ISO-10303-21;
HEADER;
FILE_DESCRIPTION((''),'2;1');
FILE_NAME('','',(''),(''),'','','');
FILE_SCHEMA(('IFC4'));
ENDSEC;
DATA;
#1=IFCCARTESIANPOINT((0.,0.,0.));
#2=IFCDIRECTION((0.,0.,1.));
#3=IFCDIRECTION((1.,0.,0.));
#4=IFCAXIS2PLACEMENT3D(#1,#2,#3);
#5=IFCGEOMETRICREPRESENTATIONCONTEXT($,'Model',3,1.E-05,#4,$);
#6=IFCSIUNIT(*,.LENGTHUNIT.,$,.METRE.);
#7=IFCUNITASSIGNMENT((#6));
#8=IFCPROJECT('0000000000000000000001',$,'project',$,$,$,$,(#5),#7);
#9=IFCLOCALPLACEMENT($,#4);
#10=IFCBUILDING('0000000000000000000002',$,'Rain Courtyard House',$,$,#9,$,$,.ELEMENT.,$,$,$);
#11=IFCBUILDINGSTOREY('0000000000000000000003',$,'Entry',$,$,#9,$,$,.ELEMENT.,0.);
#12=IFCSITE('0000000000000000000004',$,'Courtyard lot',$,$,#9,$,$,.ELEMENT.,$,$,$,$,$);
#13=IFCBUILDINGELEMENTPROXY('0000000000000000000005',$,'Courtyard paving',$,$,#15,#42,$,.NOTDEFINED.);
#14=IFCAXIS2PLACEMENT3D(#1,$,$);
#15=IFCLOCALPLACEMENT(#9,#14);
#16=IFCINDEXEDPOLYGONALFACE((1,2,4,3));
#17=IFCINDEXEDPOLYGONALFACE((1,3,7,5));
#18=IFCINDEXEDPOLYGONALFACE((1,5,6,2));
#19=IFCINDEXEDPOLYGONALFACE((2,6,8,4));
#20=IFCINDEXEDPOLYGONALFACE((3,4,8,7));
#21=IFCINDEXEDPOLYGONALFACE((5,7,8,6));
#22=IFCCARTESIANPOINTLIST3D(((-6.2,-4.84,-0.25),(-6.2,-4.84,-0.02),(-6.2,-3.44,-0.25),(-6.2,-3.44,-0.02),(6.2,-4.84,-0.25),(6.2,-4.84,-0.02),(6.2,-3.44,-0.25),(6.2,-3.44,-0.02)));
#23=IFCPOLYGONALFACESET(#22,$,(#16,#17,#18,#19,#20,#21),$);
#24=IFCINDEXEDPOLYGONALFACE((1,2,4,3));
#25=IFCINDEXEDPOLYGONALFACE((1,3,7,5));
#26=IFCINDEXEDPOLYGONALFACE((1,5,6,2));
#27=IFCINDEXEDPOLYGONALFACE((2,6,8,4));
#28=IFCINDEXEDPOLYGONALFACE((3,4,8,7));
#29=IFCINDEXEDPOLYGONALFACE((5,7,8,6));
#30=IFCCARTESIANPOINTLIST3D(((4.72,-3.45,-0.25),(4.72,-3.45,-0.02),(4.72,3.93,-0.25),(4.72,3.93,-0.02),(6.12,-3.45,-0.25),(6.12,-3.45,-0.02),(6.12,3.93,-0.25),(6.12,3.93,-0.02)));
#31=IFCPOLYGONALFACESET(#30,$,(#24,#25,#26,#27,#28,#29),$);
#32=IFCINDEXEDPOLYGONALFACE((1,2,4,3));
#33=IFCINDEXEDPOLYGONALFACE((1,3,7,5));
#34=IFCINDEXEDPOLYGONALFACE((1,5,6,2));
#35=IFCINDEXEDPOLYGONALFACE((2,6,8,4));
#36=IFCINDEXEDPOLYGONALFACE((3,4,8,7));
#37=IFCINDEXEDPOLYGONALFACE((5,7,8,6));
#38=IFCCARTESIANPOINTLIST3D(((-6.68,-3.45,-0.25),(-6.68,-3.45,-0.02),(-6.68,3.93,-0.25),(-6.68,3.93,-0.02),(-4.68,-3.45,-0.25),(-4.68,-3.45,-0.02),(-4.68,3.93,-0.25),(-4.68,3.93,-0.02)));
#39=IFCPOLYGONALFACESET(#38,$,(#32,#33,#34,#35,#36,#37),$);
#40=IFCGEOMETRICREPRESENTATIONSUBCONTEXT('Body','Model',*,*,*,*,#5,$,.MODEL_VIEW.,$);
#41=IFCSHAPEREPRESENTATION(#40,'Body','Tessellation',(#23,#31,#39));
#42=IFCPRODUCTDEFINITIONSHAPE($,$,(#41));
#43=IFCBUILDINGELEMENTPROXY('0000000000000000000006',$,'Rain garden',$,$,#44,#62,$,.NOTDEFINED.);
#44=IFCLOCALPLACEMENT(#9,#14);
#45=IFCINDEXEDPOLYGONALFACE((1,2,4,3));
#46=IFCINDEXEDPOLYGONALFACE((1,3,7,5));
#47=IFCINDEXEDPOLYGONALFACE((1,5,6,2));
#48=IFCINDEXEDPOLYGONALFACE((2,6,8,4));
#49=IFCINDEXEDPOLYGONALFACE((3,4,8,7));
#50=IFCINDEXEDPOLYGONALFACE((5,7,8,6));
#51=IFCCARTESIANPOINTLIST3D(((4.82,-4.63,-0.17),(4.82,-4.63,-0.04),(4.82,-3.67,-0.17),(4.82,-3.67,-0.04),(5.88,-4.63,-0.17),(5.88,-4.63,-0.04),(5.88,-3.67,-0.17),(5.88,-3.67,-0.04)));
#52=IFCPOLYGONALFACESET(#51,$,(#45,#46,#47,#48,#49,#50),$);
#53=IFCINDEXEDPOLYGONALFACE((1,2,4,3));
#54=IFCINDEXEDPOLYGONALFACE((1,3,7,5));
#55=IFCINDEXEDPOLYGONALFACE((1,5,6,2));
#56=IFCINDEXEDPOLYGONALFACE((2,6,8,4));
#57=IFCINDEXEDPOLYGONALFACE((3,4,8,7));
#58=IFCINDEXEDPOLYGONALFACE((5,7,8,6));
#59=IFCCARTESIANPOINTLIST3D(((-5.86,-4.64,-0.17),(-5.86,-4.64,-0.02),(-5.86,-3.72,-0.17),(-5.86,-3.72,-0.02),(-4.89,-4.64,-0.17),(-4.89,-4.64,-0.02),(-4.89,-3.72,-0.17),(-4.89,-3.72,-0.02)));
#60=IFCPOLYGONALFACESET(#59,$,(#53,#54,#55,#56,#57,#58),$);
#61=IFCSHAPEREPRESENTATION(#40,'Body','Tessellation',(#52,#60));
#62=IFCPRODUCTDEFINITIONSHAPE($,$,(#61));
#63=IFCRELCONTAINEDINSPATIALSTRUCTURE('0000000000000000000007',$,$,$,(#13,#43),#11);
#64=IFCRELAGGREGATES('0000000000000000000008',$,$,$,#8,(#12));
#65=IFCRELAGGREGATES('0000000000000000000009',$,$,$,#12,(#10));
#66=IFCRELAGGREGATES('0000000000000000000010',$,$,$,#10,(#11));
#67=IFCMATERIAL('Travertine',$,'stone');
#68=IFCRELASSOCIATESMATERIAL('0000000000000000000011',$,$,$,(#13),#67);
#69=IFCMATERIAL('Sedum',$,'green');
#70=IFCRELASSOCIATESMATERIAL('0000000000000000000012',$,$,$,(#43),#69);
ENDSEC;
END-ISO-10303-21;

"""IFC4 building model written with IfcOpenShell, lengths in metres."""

from ifc_helpers import new_model, si_unit, frame, origin_with_axes, origin_2d, place, context, subcontext, project, spatial, rectangle, extrude, material, element, save


model = new_model("IFC4")

# Units and contexts
model_context = context("Model", 3, precision=1e-05, world=origin_with_axes())
body_context = subcontext(model_context, "Body", "Model", "MODEL_VIEW")
ifc_project = project(units=[si_unit("LENGTHUNIT", "METRE")], contexts=[model_context])

# Site, building, storey
placement = place(None, origin_with_axes())
site = spatial("IfcSite", under=ifc_project, at=placement, Name="Courtyard lot", CompositionType="ELEMENT")
building = spatial("IfcBuilding", under=site, at=placement, Name="Rain Courtyard House", CompositionType="ELEMENT")
storey = spatial("IfcBuildingStorey", under=building, at=placement, Name="Entry", CompositionType="ELEMENT", Elevation=0.0)

# Building element proxies
ifc_material_1 = material(Name="Travertine", Category="stone")
element("IfcBuildingElementProxy", 1, at=placement, inside=storey, material=ifc_material_1, Name="Courtyard paving", PredefinedType="NOTDEFINED", context=body_context, shape_type="SweptSolid", body=[
    extrude(rectangle(XDim=12.4, YDim=1.4, at=origin_2d()), frame((0.0, -4.14, -0.25), z_axis=(0.0, 0.0, 1.0), x_axis=(1.0, 0.0, 0.0)), (0.0, 0.0, 1.0), 0.23),
    extrude(rectangle(XDim=1.4, YDim=7.38, at=origin_2d()), frame((5.42, 0.24, -0.25), z_axis=(0.0, 0.0, 1.0), x_axis=(1.0, 0.0, 0.0)), (0.0, 0.0, 1.0), 0.23),
    extrude(rectangle(XDim=2.0, YDim=7.38, at=origin_2d()), frame((-5.68, 0.24, -0.25), z_axis=(0.0, 0.0, 1.0), x_axis=(1.0, 0.0, 0.0)), (0.0, 0.0, 1.0), 0.23),
])
ifc_material_2 = material(Name="Sedum", Category="green")
element("IfcBuildingElementProxy", 2, at=placement, inside=storey, material=ifc_material_2, Name="Rain garden", PredefinedType="NOTDEFINED", context=body_context, shape_type="SweptSolid", body=[
    extrude(rectangle(XDim=1.06, YDim=0.96, at=origin_2d()), frame((5.35, -4.15, -0.17), z_axis=(0.0, 0.0, 1.0), x_axis=(1.0, 0.0, 0.0)), (0.0, 0.0, 1.0), 0.13),
    extrude(rectangle(XDim=0.97, YDim=0.92, at=origin_2d()), frame((-5.375, -4.18, -0.17), z_axis=(0.0, 0.0, 1.0), x_axis=(1.0, 0.0, 0.0)), (0.0, 0.0, 1.0), 0.15),
])

save(model, "model.ifc")
